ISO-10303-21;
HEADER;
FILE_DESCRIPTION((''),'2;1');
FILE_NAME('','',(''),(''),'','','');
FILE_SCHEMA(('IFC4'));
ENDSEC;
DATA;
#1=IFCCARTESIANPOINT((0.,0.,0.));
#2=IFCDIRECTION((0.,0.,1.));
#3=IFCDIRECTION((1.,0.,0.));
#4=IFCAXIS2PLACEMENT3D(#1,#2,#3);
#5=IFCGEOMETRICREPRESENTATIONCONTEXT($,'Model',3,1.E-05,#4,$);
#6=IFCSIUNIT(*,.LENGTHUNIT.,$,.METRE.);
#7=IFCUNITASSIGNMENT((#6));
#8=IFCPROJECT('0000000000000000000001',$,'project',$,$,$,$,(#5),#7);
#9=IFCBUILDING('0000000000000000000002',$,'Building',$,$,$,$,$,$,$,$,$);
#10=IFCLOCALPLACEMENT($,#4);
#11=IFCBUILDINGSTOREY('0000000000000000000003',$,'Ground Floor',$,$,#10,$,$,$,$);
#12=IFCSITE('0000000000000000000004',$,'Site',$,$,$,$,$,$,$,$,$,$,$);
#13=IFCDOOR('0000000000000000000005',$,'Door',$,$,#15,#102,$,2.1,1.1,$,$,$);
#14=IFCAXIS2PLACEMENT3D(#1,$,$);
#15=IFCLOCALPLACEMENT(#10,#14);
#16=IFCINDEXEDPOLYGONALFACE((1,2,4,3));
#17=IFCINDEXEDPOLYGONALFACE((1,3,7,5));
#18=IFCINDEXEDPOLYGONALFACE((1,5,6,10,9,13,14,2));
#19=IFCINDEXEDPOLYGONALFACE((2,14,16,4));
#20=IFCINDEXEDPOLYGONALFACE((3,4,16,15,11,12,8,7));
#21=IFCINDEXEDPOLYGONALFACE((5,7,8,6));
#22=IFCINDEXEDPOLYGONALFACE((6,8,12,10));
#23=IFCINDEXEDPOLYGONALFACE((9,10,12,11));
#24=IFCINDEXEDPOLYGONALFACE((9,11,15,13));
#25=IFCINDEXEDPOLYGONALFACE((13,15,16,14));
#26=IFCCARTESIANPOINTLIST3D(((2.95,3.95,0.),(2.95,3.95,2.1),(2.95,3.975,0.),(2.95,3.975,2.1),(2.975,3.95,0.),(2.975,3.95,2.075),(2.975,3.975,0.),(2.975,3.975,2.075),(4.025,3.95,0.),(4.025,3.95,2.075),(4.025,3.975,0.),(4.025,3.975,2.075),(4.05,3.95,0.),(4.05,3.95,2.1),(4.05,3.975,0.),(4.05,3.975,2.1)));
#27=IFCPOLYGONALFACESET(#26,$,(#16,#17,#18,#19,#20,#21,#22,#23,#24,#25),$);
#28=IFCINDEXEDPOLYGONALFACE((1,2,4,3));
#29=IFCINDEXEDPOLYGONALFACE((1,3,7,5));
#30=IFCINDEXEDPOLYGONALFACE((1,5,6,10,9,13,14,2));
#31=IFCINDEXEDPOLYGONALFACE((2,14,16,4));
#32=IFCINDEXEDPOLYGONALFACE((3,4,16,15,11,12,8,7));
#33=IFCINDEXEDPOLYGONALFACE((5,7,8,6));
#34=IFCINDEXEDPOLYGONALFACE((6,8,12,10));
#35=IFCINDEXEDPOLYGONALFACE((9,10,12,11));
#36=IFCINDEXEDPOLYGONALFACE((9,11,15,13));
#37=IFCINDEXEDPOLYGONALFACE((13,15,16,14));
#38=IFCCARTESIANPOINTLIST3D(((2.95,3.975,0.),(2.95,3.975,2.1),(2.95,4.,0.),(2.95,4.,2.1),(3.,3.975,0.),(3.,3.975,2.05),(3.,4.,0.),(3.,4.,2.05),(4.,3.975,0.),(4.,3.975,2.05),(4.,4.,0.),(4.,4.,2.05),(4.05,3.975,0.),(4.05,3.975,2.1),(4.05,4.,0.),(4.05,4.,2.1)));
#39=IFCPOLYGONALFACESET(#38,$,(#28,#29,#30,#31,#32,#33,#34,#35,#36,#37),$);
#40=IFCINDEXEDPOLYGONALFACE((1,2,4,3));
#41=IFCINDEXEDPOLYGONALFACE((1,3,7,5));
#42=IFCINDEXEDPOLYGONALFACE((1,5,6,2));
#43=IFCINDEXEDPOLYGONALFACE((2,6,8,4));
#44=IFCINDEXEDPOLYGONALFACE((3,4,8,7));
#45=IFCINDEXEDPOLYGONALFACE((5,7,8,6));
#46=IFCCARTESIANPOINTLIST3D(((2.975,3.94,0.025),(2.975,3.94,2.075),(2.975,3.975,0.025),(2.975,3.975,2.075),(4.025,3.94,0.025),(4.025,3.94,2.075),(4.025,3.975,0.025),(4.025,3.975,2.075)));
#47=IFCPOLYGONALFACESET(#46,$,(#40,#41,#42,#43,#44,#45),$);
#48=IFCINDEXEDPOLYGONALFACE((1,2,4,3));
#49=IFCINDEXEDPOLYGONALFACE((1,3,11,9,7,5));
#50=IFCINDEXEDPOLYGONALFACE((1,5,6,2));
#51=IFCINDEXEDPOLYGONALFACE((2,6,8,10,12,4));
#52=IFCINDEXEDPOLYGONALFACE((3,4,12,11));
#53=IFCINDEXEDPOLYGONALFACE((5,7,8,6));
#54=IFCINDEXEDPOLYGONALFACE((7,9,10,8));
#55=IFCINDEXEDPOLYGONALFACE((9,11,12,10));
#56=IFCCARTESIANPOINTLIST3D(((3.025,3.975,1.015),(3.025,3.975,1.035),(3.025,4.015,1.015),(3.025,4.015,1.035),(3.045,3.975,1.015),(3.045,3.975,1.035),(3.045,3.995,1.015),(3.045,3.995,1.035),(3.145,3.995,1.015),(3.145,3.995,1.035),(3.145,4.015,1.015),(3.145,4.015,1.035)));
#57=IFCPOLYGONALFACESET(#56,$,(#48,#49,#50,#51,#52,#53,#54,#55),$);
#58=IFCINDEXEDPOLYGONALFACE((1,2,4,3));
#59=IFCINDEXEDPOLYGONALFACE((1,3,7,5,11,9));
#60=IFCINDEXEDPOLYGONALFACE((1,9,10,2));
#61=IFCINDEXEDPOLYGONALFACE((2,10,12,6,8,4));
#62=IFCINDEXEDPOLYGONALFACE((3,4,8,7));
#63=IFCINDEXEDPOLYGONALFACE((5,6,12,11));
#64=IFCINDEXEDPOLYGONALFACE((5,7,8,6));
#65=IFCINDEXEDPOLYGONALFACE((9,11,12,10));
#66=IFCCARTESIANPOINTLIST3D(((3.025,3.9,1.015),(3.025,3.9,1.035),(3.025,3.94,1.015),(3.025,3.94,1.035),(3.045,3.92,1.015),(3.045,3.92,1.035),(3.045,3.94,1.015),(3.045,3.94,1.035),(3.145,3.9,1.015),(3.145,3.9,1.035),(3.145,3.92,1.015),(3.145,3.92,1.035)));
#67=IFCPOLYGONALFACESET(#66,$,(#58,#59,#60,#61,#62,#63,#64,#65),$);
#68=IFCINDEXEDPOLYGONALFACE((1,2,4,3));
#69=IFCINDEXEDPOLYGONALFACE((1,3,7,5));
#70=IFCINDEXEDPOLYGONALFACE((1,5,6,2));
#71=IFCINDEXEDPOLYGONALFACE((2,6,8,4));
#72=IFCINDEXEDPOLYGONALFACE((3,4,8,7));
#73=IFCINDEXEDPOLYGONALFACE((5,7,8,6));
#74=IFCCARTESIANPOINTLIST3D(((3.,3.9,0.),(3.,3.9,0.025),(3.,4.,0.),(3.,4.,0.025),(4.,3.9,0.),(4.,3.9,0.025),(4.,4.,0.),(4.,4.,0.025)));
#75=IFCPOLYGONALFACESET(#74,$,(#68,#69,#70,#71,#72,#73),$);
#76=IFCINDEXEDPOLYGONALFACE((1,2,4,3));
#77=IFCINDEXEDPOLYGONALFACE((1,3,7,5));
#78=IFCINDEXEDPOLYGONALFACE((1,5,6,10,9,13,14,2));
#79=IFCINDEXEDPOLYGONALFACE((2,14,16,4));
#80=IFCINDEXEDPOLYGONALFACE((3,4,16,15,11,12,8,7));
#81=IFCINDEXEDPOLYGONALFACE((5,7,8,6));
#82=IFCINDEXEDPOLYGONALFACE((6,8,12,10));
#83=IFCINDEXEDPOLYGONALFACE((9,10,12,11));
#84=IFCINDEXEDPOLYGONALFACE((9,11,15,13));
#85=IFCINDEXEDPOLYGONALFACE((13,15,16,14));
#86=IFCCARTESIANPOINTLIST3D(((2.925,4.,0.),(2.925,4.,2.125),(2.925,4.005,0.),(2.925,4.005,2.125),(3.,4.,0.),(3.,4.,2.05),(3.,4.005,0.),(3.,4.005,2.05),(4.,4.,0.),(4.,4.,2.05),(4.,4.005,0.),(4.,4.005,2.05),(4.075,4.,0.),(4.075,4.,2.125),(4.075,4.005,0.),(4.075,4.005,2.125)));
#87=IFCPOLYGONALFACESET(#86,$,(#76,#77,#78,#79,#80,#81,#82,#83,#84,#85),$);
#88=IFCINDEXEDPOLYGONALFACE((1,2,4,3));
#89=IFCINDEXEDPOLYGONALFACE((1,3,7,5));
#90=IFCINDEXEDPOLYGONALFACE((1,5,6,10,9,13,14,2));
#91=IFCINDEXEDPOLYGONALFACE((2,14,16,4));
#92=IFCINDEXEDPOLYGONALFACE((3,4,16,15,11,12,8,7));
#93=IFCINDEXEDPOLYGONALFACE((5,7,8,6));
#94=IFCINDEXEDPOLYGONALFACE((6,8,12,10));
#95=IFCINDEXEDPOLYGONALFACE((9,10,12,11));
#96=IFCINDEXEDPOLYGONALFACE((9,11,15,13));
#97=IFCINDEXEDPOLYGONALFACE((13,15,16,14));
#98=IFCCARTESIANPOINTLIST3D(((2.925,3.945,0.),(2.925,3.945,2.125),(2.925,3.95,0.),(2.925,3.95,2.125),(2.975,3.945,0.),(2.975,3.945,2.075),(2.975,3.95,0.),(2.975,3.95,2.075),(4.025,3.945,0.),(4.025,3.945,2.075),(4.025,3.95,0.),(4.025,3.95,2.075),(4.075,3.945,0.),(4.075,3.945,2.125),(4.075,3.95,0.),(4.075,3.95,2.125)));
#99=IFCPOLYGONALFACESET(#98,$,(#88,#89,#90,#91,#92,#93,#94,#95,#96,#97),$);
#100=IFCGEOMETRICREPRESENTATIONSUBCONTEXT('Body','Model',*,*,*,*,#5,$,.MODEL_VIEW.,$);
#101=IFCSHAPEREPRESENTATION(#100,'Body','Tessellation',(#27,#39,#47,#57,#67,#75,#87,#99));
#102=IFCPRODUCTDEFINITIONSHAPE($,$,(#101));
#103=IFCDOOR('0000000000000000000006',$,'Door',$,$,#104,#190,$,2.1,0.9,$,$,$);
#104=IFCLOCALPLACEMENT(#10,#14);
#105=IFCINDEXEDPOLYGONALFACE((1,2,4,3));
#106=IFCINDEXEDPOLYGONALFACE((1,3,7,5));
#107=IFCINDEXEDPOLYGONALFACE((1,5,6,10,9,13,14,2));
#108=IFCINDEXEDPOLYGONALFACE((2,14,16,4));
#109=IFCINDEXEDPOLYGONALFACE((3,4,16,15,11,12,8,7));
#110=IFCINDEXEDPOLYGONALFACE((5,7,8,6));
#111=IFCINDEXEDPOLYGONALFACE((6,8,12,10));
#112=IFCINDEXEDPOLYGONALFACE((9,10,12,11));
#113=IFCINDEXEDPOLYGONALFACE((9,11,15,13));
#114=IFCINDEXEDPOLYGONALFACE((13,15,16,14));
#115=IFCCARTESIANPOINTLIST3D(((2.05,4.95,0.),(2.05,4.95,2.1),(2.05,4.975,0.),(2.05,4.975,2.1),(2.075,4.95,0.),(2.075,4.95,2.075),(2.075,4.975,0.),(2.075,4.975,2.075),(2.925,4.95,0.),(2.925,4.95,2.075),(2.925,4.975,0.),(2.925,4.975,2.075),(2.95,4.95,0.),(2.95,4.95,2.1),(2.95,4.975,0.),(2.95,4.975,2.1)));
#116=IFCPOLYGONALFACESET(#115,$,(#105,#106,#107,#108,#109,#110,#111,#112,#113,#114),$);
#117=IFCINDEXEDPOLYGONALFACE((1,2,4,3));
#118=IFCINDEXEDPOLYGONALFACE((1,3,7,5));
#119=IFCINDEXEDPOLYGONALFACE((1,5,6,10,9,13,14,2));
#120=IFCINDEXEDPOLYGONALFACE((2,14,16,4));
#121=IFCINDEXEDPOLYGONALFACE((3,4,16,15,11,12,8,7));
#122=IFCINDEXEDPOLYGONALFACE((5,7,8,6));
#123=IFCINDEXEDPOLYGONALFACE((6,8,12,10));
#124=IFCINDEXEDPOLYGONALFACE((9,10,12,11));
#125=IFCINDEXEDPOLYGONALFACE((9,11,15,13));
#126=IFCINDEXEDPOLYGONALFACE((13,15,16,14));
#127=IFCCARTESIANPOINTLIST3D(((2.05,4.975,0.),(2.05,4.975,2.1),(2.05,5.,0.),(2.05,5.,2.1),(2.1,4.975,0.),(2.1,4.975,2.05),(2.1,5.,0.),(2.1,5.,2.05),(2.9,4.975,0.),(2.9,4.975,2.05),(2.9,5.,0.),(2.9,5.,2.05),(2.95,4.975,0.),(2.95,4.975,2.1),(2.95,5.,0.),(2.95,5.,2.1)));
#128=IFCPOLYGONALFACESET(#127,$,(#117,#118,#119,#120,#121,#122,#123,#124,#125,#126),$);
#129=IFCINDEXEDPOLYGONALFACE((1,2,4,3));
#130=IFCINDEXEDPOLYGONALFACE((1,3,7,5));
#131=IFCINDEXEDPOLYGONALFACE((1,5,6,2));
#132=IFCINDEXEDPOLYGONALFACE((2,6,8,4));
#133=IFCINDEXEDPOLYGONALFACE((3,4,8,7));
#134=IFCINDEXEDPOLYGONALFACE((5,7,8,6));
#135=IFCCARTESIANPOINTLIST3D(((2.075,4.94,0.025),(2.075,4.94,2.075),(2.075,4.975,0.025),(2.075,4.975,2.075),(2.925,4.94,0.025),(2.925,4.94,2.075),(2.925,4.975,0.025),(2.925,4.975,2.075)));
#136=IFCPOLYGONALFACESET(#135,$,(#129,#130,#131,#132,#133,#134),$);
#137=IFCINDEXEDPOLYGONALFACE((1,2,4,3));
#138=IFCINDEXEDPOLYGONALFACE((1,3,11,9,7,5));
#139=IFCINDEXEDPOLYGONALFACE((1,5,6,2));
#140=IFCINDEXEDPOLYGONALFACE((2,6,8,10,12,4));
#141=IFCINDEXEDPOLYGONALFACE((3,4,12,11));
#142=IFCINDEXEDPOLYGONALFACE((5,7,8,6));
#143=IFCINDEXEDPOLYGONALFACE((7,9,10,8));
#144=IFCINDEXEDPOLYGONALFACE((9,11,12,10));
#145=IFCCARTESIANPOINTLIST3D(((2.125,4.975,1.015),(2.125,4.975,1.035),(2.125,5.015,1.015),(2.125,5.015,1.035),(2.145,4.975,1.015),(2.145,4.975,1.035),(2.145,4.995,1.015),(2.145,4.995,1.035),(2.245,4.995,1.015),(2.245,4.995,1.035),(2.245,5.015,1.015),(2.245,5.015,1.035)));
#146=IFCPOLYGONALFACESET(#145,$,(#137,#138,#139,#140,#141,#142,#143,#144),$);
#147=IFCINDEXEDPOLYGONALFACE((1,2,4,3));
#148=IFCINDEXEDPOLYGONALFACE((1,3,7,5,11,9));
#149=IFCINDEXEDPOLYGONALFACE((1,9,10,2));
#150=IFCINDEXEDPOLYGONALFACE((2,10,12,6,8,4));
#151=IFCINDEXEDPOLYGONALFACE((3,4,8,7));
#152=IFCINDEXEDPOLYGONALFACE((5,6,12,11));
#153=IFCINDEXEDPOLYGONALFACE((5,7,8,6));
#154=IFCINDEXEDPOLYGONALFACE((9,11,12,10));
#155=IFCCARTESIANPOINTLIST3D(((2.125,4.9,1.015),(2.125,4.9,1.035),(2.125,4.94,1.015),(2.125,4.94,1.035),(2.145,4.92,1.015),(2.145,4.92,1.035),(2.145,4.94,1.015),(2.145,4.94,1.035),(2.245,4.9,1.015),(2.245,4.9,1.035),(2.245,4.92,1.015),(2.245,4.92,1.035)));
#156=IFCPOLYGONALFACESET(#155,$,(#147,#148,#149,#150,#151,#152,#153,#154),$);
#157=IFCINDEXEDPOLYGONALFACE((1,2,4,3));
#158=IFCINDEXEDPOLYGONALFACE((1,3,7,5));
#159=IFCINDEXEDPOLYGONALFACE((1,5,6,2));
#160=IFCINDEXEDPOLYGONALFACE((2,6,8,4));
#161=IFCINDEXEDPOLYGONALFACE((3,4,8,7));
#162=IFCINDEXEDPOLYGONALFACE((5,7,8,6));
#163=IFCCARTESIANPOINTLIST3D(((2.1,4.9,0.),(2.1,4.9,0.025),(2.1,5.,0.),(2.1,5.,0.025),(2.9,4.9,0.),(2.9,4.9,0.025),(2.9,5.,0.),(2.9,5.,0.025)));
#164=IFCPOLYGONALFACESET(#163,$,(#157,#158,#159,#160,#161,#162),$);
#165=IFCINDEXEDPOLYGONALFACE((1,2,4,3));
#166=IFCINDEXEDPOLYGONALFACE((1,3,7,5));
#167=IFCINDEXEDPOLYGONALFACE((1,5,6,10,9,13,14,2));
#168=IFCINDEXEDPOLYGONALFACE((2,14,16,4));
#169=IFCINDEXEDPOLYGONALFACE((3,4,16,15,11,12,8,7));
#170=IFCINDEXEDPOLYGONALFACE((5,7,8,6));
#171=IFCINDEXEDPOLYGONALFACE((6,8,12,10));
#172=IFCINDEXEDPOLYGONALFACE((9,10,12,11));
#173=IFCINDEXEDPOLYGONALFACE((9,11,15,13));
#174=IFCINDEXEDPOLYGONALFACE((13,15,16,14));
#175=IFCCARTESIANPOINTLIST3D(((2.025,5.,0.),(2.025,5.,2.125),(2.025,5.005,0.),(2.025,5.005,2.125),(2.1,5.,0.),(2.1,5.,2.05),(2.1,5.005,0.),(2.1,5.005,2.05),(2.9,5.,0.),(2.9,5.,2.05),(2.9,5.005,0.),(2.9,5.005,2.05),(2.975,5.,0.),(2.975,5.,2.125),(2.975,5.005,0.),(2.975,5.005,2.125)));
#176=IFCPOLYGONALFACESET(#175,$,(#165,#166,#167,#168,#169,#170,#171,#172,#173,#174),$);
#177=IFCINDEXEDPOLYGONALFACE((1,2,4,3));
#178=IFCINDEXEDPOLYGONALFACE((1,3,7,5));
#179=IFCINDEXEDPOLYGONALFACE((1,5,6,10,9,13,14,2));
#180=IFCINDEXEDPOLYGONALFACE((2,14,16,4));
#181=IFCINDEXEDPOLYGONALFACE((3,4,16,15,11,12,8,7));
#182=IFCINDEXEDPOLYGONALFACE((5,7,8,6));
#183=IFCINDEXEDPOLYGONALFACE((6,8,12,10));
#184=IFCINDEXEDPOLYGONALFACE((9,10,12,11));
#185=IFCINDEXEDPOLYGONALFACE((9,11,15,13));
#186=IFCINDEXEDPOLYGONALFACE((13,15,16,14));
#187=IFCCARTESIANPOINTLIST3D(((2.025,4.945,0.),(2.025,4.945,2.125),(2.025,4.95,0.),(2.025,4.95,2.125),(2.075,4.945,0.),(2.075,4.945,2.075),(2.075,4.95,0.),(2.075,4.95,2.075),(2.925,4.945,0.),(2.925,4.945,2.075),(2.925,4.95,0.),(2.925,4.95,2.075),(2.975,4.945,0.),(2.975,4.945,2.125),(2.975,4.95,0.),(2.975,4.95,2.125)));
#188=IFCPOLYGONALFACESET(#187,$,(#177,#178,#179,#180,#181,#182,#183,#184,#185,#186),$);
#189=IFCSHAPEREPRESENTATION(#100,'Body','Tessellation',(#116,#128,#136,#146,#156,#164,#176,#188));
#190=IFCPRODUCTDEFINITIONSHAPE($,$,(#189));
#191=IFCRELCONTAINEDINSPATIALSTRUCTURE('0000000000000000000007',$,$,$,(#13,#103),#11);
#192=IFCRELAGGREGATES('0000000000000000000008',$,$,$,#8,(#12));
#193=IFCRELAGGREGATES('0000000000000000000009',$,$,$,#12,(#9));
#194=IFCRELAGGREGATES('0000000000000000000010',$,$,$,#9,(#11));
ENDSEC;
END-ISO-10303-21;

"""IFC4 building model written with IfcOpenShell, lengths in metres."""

from ifc_helpers import new_model, si_unit, frame, origin_with_axes, place, context, subcontext, project, spatial, line, indexed_curve, outline, extrude, element, save


model = new_model("IFC4")

# Units and contexts
model_context = context("Model", 3, precision=1e-05, world=origin_with_axes())
body_context = subcontext(model_context, "Body", "Model", "MODEL_VIEW")
ifc_project = project(units=[si_unit("LENGTHUNIT", "METRE")], contexts=[model_context])

# Site, building, storey
site = spatial("IfcSite", under=ifc_project, Name="Site")
building = spatial("IfcBuilding", under=site, Name="Building")
storey_placement = place(None, origin_with_axes())
storey = spatial("IfcBuildingStorey", under=building, at=storey_placement, Name="Ground Floor")

# Doors
door_1_placement = place(storey_placement, frame((4.05, 4.0, 0.0), z_axis=(0.0, 0.0, 1.0), x_axis=(-1.0, 0.0, 0.0)))
element("IfcDoor", 1, at=door_1_placement, inside=storey, Name="Door", OverallHeight=2.1, OverallWidth=1.1, context=body_context, shape_type="SweptSolid", body=[
    extrude(outline(indexed_curve([(0.0, 0.0), (0.0, 2.1), (1.1, 2.1), (1.1, 0.0), (1.075, 0.0), (1.075, 2.075), (0.025, 2.075), (0.025, 0.0)], segments=[line(1, 2, 3, 4, 5, 6, 7, 8, 1)])), frame((0.0, 0.025, 0.0), z_axis=(0.0, -1.0, 0.0), x_axis=(1.0, 0.0, 0.0)), (0.0, 0.0, -1.0), 0.025),
    extrude(outline(indexed_curve([(0.0, 0.0), (0.0, 2.1), (1.1, 2.1), (1.1, 0.0), (1.05, 0.0), (1.05, 2.05), (0.05, 2.05), (0.05, 0.0)], segments=[line(1, 2, 3, 4, 5, 6, 7, 8, 1)])), frame((0.0, 0.0, 0.0), z_axis=(0.0, -1.0, 0.0), x_axis=(1.0, 0.0, 0.0)), (0.0, 0.0, -1.0), 0.025),
    extrude(outline(indexed_curve([(0.0, 0.0), (1.05, 0.0), (1.05, 0.035), (0.0, 0.035)], segments=[line(1, 2, 3, 4, 1)])), frame((0.025, 0.025, 0.025), z_axis=(0.0, 0.0, 1.0), x_axis=(1.0, 0.0, 0.0)), (0.0, 0.0, 1.0), 2.05),
    extrude(outline(indexed_curve([(0.0, 0.0), (0.0, -0.04), (-0.12, -0.04), (-0.12, -0.02), (-0.02, -0.02), (-0.02, 0.0)], segments=[line(1, 2, 3, 4, 5, 6, 1)])), frame((1.025, 0.025, 1.015), z_axis=(0.0, 0.0, 1.0), x_axis=(1.0, 0.0, 0.0)), (0.0, 0.0, 1.0), 0.02),
    extrude(outline(indexed_curve([(0.0, 0.0), (0.0, 0.04), (-0.12, 0.04), (-0.12, 0.02), (-0.02, 0.02), (-0.02, 0.0)], segments=[line(1, 2, 3, 4, 5, 6, 1)])), frame((1.025, 0.06, 1.015), z_axis=(0.0, 0.0, 1.0), x_axis=(1.0, 0.0, 0.0)), (0.0, 0.0, 1.0), 0.02),
    extrude(outline(indexed_curve([(0.0, 0.0), (1.0, 0.0), (1.0, 0.1), (0.0, 0.1)], segments=[line(1, 2, 3, 4, 1)])), frame((0.05, 0.0, 0.0), z_axis=(0.0, 0.0, 1.0), x_axis=(1.0, 0.0, 0.0)), (0.0, 0.0, 1.0), 0.025),
    extrude(outline(indexed_curve([(0.0, 0.0), (0.0, 2.125), (1.15, 2.125), (1.15, 0.0), (1.075, 0.0), (1.075, 2.05), (0.075, 2.05), (0.075, 0.0)], segments=[line(1, 2, 3, 4, 5, 6, 7, 8, 1)])), frame((-0.025, -0.005, 0.0), z_axis=(0.0, -1.0, 0.0), x_axis=(1.0, 0.0, 0.0)), (0.0, 0.0, -1.0), 0.005),
    extrude(outline(indexed_curve([(0.0, 0.0), (0.0, 2.125), (1.15, 2.125), (1.15, 0.0), (1.1, 0.0), (1.1, 2.075), (0.05, 2.075), (0.05, 0.0)], segments=[line(1, 2, 3, 4, 5, 6, 7, 8, 1)])), frame((-0.025, 0.05, 0.0), z_axis=(0.0, -1.0, 0.0), x_axis=(1.0, 0.0, 0.0)), (0.0, 0.0, -1.0), 0.005),
])
door_2_placement = place(storey_placement, frame((2.95, 5.0, 0.0), z_axis=(0.0, 0.0, 1.0), x_axis=(-1.0, 0.0, 0.0)))
element("IfcDoor", 2, at=door_2_placement, inside=storey, Name="Door", OverallHeight=2.1, OverallWidth=0.9, context=body_context, shape_type="SweptSolid", body=[
    extrude(outline(indexed_curve([(0.0, 0.0), (0.0, 2.1), (0.9, 2.1), (0.9, 0.0), (0.875, 0.0), (0.875, 2.075), (0.025, 2.075), (0.025, 0.0)], segments=[line(1, 2, 3, 4, 5, 6, 7, 8, 1)])), frame((0.0, 0.025, 0.0), z_axis=(0.0, -1.0, 0.0), x_axis=(1.0, 0.0, 0.0)), (0.0, 0.0, -1.0), 0.025),
    extrude(outline(indexed_curve([(0.0, 0.0), (0.0, 2.1), (0.9, 2.1), (0.9, 0.0), (0.85, 0.0), (0.85, 2.05), (0.05, 2.05), (0.05, 0.0)], segments=[line(1, 2, 3, 4, 5, 6, 7, 8, 1)])), frame((0.0, 0.0, 0.0), z_axis=(0.0, -1.0, 0.0), x_axis=(1.0, 0.0, 0.0)), (0.0, 0.0, -1.0), 0.025),
    extrude(outline(indexed_curve([(0.0, 0.0), (0.85, 0.0), (0.85, 0.035), (0.0, 0.035)], segments=[line(1, 2, 3, 4, 1)])), frame((0.025, 0.025, 0.025), z_axis=(0.0, 0.0, 1.0), x_axis=(1.0, 0.0, 0.0)), (0.0, 0.0, 1.0), 2.05),
    extrude(outline(indexed_curve([(0.0, 0.0), (0.0, -0.04), (-0.12, -0.04), (-0.12, -0.02), (-0.02, -0.02), (-0.02, 0.0)], segments=[line(1, 2, 3, 4, 5, 6, 1)])), frame((0.825, 0.025, 1.015), z_axis=(0.0, 0.0, 1.0), x_axis=(1.0, 0.0, 0.0)), (0.0, 0.0, 1.0), 0.02),
    extrude(outline(indexed_curve([(0.0, 0.0), (0.0, 0.04), (-0.12, 0.04), (-0.12, 0.02), (-0.02, 0.02), (-0.02, 0.0)], segments=[line(1, 2, 3, 4, 5, 6, 1)])), frame((0.825, 0.06, 1.015), z_axis=(0.0, 0.0, 1.0), x_axis=(1.0, 0.0, 0.0)), (0.0, 0.0, 1.0), 0.02),
    extrude(outline(indexed_curve([(0.0, 0.0), (0.8, 0.0), (0.8, 0.1), (0.0, 0.1)], segments=[line(1, 2, 3, 4, 1)])), frame((0.05, 0.0, 0.0), z_axis=(0.0, 0.0, 1.0), x_axis=(1.0, 0.0, 0.0)), (0.0, 0.0, 1.0), 0.025),
    extrude(outline(indexed_curve([(0.0, 0.0), (0.0, 2.125), (0.95, 2.125), (0.95, 0.0), (0.875, 0.0), (0.875, 2.05), (0.075, 2.05), (0.075, 0.0)], segments=[line(1, 2, 3, 4, 5, 6, 7, 8, 1)])), frame((-0.025, -0.005, 0.0), z_axis=(0.0, -1.0, 0.0), x_axis=(1.0, 0.0, 0.0)), (0.0, 0.0, -1.0), 0.005),
    extrude(outline(indexed_curve([(0.0, 0.0), (0.0, 2.125), (0.95, 2.125), (0.95, 0.0), (0.9, 0.0), (0.9, 2.075), (0.05, 2.075), (0.05, 0.0)], segments=[line(1, 2, 3, 4, 5, 6, 7, 8, 1)])), frame((-0.025, 0.05, 0.0), z_axis=(0.0, -1.0, 0.0), x_axis=(1.0, 0.0, 0.0)), (0.0, 0.0, -1.0), 0.005),
])

save(model, "model.ifc")
